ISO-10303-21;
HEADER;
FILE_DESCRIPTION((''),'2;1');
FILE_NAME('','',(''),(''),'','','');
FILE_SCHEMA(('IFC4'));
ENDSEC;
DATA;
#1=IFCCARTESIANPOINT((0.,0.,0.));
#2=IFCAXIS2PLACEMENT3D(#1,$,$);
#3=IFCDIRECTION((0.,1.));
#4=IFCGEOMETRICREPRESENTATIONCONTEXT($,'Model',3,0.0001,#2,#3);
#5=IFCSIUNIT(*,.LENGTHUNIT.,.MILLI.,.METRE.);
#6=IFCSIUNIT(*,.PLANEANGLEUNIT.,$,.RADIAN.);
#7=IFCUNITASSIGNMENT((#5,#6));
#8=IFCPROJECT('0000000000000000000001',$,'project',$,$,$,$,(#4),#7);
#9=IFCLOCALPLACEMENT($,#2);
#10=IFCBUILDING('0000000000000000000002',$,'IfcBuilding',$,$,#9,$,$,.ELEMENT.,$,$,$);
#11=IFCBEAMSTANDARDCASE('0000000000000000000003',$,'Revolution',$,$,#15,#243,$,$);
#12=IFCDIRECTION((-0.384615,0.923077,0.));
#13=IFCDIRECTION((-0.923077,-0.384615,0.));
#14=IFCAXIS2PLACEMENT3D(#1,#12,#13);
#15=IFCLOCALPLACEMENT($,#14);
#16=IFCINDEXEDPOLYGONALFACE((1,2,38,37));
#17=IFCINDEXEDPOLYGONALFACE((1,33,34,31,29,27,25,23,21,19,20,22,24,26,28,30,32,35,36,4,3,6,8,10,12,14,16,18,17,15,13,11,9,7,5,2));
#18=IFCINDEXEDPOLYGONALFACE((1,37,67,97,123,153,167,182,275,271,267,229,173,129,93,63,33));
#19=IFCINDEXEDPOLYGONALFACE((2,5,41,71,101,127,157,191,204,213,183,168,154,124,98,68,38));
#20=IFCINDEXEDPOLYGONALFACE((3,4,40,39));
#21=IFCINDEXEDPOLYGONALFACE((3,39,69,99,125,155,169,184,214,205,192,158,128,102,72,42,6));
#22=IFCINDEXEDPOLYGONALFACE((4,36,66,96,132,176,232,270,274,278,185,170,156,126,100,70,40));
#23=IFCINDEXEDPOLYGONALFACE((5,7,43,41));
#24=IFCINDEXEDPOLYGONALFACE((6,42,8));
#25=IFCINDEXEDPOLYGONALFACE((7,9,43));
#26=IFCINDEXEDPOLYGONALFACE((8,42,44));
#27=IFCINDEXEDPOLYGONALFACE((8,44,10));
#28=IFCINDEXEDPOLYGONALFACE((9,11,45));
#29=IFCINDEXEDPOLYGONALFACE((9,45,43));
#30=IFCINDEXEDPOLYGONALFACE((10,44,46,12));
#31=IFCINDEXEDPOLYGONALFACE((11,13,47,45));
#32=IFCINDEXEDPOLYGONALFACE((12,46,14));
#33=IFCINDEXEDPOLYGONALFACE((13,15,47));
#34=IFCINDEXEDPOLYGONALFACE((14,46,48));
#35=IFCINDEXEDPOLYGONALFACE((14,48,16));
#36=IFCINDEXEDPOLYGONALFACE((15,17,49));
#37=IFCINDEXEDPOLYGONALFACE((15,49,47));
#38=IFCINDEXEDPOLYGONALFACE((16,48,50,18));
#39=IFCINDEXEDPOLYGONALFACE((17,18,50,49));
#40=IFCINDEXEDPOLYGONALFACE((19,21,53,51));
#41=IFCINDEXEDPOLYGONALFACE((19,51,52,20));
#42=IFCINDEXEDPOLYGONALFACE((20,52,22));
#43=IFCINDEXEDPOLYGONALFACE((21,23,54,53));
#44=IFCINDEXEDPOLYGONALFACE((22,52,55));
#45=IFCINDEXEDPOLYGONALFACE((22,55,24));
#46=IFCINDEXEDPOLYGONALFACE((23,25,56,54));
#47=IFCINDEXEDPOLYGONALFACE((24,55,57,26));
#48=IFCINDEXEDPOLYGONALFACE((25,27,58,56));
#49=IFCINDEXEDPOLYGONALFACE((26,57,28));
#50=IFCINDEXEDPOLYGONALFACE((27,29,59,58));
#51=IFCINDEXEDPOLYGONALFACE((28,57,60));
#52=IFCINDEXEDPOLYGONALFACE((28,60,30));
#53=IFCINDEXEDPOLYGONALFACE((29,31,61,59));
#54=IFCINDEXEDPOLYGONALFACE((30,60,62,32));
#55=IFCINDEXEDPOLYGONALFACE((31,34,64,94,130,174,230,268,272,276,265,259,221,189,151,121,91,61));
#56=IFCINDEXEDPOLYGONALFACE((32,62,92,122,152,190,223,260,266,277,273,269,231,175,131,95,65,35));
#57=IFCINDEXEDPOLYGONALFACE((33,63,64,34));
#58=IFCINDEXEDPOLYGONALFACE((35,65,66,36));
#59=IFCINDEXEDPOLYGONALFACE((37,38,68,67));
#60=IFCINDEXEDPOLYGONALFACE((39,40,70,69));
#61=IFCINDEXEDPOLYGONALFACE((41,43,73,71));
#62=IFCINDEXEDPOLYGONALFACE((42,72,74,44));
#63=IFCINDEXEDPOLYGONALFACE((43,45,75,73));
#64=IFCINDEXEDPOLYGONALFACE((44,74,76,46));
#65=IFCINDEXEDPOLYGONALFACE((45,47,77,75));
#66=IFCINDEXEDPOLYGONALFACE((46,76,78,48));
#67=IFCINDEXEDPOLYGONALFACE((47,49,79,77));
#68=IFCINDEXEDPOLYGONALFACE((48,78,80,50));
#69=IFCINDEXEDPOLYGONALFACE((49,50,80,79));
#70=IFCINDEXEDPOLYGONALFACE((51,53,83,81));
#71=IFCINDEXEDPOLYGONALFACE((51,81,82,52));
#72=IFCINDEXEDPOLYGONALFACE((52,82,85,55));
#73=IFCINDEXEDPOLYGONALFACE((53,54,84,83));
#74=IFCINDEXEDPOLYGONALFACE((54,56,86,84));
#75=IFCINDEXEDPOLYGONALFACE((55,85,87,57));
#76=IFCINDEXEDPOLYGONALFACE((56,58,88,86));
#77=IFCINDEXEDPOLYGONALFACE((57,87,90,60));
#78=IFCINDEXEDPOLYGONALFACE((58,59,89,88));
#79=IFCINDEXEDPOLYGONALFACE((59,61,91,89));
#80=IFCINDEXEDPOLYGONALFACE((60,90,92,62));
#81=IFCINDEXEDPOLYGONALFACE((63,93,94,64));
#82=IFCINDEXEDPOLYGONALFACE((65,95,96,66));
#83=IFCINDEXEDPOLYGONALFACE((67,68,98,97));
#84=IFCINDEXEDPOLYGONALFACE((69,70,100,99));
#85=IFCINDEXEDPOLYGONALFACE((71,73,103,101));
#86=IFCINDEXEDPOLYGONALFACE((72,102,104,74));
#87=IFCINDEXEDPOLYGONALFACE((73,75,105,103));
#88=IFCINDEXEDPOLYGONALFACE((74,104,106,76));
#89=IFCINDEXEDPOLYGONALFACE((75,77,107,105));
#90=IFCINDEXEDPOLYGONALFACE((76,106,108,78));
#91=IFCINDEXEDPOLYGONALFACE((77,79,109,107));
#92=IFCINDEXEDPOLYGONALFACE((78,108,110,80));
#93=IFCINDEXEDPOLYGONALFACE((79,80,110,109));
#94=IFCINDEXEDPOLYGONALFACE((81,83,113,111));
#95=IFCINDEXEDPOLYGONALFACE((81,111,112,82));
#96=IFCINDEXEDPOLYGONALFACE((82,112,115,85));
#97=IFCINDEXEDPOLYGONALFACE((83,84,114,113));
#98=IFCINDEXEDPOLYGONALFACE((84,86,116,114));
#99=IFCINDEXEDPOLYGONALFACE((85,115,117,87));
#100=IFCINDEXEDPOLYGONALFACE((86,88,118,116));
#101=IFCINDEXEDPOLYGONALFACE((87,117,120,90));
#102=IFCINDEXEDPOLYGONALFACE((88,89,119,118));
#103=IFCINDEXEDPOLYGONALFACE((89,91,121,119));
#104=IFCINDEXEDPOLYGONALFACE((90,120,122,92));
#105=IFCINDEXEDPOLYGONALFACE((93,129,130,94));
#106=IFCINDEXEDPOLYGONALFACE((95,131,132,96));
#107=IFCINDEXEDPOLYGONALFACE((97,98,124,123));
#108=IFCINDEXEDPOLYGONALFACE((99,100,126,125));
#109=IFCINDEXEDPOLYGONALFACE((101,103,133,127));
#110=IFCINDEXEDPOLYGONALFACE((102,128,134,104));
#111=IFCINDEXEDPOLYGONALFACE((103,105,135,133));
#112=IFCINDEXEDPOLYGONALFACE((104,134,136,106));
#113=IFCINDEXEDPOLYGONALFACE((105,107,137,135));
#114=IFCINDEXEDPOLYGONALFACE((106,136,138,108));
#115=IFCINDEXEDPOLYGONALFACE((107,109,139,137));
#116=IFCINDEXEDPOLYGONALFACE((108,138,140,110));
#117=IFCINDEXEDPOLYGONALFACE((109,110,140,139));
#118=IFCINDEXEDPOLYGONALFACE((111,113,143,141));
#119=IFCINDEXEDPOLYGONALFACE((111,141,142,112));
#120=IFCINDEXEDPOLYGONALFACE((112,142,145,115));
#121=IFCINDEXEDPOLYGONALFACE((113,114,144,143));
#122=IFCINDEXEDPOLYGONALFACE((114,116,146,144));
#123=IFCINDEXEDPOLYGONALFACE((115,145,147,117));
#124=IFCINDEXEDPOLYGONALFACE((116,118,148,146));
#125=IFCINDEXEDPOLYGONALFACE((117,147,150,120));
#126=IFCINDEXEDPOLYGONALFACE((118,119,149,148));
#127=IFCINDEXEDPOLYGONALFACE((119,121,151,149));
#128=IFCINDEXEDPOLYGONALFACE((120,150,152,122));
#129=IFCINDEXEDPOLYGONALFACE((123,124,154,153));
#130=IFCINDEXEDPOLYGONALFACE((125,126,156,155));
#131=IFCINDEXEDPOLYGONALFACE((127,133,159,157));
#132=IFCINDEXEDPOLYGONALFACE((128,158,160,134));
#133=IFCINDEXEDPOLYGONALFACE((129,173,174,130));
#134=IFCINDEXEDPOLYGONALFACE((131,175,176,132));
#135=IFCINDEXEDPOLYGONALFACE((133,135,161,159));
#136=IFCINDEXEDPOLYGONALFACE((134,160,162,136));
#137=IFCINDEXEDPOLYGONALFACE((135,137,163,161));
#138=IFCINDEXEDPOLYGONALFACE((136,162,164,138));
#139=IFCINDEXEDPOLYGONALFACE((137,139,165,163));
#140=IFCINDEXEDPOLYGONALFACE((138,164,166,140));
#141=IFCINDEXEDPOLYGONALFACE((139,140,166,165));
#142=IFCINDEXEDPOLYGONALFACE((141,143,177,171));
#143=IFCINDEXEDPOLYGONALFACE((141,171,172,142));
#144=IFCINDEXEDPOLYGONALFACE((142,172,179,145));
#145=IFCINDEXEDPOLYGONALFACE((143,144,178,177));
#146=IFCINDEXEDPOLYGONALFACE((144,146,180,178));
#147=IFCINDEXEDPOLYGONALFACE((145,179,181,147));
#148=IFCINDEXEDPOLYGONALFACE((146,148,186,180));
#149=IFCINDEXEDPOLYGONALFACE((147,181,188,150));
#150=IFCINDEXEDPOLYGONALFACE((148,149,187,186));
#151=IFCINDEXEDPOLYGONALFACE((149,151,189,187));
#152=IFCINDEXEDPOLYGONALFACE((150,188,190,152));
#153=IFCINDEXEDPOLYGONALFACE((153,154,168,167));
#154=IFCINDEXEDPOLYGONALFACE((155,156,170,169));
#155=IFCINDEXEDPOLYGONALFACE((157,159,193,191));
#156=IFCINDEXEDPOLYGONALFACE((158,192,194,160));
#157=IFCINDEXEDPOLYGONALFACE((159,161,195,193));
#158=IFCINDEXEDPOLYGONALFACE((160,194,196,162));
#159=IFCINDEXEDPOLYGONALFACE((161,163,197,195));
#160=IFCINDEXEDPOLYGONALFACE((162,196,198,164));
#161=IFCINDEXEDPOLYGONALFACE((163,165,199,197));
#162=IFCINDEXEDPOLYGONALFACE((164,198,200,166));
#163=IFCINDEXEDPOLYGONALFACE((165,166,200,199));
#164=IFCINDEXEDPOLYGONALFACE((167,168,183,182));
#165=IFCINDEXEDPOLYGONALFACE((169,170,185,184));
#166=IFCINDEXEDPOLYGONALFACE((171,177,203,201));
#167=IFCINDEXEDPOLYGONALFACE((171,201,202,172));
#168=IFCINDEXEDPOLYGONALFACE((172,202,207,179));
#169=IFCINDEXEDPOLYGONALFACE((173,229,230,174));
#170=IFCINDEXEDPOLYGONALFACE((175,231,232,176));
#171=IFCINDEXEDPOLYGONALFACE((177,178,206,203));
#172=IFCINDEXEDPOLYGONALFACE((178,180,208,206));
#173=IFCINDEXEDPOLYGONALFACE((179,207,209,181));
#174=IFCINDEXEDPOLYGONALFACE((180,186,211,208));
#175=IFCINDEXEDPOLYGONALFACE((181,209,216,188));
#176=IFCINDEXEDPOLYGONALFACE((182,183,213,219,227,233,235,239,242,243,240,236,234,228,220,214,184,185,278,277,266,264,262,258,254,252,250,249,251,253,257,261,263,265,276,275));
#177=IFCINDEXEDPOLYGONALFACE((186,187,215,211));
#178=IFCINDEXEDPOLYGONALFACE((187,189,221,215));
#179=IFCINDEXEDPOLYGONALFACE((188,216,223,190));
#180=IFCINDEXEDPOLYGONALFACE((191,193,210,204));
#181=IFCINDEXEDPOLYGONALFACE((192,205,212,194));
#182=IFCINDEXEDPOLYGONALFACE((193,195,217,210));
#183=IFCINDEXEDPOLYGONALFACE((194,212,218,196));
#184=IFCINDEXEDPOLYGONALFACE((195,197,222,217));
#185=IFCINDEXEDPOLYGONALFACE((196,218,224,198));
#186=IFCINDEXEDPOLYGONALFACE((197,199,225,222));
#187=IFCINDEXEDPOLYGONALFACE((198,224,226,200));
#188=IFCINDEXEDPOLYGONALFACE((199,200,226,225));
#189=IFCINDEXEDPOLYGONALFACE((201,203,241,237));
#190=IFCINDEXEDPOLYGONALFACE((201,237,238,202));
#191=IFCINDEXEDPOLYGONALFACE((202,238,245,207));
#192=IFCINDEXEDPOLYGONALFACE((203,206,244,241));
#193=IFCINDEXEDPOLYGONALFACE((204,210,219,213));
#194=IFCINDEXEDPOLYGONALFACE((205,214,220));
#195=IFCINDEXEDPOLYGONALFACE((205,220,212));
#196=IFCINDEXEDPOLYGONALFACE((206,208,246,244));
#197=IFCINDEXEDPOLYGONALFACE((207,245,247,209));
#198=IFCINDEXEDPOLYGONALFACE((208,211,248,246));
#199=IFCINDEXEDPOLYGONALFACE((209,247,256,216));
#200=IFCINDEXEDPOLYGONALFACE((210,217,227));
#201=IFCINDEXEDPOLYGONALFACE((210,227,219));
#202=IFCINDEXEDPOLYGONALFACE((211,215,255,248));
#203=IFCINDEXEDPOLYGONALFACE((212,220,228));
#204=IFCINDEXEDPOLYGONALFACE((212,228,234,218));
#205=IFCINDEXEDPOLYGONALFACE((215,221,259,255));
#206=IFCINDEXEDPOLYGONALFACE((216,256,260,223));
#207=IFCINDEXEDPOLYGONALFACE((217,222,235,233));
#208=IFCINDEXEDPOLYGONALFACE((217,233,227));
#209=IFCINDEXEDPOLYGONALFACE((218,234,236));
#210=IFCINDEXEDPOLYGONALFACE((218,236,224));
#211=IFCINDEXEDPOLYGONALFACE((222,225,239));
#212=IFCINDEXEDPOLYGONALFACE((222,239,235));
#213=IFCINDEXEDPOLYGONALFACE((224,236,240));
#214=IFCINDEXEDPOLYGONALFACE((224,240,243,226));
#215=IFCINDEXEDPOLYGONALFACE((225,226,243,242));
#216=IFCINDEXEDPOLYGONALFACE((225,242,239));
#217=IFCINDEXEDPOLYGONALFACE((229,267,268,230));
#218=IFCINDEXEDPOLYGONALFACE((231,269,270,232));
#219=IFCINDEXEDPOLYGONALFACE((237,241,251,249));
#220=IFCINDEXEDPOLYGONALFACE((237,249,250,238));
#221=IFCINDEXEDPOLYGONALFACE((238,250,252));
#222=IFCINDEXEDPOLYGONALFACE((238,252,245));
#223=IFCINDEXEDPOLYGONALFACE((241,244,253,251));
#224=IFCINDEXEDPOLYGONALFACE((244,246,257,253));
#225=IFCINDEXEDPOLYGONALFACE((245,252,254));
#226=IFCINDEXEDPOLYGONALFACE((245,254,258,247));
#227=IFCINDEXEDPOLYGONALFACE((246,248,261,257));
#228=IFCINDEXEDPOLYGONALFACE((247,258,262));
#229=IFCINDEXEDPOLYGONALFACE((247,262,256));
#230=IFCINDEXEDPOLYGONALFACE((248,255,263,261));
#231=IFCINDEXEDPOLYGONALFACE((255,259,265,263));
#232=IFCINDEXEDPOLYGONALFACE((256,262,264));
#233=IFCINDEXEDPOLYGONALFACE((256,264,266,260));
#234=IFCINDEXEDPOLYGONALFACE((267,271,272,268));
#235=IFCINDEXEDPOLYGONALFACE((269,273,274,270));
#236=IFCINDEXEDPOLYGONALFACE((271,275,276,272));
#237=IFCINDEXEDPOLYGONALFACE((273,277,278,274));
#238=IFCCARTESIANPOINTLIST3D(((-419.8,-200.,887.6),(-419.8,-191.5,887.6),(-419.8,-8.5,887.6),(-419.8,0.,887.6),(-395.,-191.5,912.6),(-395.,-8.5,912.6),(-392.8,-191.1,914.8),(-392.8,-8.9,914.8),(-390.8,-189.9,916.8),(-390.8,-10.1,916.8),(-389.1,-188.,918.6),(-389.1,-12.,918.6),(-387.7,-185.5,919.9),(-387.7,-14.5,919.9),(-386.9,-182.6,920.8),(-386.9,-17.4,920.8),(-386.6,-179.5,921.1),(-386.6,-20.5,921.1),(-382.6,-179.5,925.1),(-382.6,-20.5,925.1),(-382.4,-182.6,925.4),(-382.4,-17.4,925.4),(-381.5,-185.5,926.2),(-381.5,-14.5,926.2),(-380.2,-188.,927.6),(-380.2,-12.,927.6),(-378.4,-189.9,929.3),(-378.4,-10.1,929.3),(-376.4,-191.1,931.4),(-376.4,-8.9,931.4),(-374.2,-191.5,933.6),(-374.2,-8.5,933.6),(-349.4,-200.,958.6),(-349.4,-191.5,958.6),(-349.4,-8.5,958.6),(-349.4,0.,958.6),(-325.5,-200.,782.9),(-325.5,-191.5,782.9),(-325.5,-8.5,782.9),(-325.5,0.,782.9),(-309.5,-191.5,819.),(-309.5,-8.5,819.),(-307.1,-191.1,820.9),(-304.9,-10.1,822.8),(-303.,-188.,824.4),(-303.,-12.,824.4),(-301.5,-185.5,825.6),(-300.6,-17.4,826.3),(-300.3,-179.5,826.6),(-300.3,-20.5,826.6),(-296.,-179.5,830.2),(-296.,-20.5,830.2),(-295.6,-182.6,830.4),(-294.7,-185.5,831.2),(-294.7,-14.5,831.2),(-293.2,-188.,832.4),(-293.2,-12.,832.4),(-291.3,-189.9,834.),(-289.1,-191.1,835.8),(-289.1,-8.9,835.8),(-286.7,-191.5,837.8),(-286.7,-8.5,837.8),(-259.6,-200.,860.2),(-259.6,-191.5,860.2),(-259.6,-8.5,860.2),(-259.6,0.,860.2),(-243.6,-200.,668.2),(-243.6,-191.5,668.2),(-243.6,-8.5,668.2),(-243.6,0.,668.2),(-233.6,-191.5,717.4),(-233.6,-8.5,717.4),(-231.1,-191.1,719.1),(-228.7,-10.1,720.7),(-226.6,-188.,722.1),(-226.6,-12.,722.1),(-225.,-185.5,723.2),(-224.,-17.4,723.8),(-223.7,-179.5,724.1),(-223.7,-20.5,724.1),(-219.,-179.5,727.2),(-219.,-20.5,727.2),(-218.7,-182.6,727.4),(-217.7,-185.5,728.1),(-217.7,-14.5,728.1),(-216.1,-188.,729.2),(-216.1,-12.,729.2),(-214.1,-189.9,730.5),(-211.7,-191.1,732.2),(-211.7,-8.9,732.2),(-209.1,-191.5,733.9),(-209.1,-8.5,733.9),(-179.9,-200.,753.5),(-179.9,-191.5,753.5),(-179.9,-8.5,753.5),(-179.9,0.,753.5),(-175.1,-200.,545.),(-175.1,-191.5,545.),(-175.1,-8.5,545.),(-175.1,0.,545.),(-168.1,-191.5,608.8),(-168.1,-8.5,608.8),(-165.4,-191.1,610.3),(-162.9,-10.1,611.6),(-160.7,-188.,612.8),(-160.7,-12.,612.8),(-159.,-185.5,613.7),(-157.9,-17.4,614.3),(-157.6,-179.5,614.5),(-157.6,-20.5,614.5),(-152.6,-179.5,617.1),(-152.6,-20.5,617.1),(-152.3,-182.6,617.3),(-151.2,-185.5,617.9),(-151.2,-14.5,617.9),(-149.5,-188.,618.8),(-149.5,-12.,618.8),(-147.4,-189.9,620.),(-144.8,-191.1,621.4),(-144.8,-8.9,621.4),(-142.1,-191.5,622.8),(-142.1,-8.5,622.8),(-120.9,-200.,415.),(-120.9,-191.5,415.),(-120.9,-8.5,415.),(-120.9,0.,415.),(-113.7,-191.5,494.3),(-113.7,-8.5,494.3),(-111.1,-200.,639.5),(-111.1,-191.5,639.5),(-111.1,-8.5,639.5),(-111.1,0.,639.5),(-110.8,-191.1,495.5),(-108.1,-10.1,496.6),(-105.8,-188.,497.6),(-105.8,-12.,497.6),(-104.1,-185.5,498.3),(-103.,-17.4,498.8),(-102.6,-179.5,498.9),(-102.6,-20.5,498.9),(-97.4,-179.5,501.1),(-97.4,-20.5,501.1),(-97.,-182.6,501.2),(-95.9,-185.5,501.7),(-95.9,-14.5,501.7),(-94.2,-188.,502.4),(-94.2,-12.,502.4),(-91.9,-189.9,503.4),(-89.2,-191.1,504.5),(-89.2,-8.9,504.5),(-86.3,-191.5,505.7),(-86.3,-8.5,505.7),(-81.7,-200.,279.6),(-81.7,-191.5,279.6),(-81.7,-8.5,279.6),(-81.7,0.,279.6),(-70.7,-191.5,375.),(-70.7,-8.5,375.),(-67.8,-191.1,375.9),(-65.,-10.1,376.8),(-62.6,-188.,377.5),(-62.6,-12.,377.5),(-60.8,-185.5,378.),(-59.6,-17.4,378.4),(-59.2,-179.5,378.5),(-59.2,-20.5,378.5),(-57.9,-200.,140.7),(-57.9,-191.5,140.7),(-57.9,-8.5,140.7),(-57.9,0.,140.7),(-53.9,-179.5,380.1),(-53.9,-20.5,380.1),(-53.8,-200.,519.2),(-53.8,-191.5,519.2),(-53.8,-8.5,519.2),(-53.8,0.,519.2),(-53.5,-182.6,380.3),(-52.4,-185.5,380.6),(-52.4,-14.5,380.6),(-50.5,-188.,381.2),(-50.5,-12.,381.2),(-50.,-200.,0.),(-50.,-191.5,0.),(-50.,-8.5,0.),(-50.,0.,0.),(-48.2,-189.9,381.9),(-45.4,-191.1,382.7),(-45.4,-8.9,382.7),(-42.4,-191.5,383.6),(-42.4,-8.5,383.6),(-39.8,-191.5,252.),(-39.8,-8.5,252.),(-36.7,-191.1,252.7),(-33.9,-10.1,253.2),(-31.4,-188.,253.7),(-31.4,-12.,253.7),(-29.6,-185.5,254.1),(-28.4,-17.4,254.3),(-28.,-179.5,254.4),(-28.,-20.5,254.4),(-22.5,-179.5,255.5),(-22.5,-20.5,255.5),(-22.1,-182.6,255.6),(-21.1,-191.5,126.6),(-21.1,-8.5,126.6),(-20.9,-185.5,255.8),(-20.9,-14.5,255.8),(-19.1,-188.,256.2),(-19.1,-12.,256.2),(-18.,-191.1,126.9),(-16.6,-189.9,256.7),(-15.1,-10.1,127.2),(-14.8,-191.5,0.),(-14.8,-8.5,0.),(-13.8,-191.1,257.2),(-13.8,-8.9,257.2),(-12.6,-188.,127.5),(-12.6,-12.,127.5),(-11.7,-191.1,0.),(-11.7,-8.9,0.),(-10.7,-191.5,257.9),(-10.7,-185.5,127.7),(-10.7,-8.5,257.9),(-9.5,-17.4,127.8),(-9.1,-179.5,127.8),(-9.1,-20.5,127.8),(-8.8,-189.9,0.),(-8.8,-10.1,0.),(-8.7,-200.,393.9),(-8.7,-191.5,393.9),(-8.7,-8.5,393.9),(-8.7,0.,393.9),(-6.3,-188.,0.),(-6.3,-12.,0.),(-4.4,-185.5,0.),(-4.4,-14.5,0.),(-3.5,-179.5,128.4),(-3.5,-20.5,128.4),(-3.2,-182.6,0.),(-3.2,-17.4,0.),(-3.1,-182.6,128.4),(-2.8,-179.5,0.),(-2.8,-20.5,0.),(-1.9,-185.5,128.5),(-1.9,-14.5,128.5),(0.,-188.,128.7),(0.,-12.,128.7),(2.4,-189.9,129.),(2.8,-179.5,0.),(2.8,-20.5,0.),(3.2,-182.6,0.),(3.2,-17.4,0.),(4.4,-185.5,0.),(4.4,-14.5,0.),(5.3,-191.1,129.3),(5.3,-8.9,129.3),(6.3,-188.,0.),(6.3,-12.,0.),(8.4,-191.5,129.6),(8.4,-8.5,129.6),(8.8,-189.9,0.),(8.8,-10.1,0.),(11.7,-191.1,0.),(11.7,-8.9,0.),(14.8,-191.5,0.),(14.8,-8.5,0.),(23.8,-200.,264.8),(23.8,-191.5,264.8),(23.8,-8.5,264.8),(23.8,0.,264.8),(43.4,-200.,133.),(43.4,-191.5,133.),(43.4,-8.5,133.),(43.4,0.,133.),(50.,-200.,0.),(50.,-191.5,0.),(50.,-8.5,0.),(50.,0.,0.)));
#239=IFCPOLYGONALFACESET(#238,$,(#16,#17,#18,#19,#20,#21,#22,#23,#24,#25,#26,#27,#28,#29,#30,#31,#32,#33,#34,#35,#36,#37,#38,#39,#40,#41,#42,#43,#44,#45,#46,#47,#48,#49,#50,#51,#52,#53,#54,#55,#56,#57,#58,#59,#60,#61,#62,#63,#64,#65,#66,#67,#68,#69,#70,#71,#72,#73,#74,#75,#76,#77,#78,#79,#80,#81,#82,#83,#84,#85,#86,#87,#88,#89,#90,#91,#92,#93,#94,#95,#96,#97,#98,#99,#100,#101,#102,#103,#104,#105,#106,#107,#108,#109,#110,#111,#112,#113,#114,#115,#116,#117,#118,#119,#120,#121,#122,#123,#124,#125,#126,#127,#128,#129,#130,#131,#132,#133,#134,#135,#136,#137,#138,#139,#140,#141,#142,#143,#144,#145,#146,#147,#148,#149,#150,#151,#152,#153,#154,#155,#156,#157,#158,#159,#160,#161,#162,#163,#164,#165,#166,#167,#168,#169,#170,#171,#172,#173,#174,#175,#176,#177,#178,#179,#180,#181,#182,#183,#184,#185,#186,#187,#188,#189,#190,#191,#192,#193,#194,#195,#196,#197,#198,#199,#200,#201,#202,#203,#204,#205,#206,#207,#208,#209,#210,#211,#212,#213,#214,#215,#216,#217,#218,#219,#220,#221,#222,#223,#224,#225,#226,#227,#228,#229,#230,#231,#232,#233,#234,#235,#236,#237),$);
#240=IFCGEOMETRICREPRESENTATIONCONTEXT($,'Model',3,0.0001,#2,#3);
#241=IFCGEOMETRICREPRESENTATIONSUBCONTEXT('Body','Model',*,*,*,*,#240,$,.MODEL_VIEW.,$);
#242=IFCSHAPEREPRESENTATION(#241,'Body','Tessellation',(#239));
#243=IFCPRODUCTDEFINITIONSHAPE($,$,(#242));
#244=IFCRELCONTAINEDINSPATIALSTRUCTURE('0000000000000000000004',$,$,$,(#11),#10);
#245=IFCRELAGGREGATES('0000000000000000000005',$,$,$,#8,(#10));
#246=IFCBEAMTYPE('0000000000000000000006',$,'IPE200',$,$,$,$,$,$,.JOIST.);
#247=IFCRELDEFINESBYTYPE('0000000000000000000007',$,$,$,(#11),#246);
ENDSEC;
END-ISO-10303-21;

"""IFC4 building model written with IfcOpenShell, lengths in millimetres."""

from ifc_helpers import new_model, entity, si_unit, direction, frame, origin, place, context, subcontext, project, spatial, type_object, element, save


model = new_model("IFC4")

# Units and contexts
model_context_1 = context("Model", 3, precision=0.0001, world=origin(), true_north=direction((0.0, 1.0)))
model_context_2 = context("Model", 3, precision=0.0001, world=origin(), true_north=direction((0.0, 1.0)))
body_context = subcontext(model_context_1, "Body", "Model", "MODEL_VIEW")
ifc_project = project(units=[si_unit("LENGTHUNIT", "METRE", prefix="MILLI"), si_unit("PLANEANGLEUNIT", "RADIAN")], contexts=[model_context_2])

# Building
building_placement = place(None, origin())
building = spatial("IfcBuilding", under=ifc_project, at=building_placement, Name="IfcBuilding", CompositionType="ELEMENT")

# Beam
beam_type = type_object("IfcBeamType", Name="IPE200", PredefinedType="JOIST")
beam_1_placement = place(None, frame((0.0, 0.0, 0.0), z_axis=(-0.384615, 0.923077, 0.0), x_axis=(-0.923077, -0.384615, 0.0)))
element("IfcBeamStandardCase", 1, at=beam_1_placement, inside=building, type_object=beam_type, Name="Revolution", context=body_context, shape_type="SweptSolid", body=[
    entity("IfcRevolvedAreaSolid", entity("IfcIShapeProfileDef", "AREA", None, None, 100.0, 200.0, 5.6, 8.5, 12.0), entity("IfcAxis2Placement3D", entity("IfcCartesianPoint", [0.0, -100.0, 0.0]), entity("IfcDirection", [0.0, 0.0, 1.0]), entity("IfcDirection", [1.0, 0.0, 0.0])), entity("IfcAxis1Placement", entity("IfcCartesianPoint", [-1300.0, 100.0, 0.0]), entity("IfcDirection", [0.0, -1.0, 0.0])), 0.789582),
])

save(model, "model.ifc")
